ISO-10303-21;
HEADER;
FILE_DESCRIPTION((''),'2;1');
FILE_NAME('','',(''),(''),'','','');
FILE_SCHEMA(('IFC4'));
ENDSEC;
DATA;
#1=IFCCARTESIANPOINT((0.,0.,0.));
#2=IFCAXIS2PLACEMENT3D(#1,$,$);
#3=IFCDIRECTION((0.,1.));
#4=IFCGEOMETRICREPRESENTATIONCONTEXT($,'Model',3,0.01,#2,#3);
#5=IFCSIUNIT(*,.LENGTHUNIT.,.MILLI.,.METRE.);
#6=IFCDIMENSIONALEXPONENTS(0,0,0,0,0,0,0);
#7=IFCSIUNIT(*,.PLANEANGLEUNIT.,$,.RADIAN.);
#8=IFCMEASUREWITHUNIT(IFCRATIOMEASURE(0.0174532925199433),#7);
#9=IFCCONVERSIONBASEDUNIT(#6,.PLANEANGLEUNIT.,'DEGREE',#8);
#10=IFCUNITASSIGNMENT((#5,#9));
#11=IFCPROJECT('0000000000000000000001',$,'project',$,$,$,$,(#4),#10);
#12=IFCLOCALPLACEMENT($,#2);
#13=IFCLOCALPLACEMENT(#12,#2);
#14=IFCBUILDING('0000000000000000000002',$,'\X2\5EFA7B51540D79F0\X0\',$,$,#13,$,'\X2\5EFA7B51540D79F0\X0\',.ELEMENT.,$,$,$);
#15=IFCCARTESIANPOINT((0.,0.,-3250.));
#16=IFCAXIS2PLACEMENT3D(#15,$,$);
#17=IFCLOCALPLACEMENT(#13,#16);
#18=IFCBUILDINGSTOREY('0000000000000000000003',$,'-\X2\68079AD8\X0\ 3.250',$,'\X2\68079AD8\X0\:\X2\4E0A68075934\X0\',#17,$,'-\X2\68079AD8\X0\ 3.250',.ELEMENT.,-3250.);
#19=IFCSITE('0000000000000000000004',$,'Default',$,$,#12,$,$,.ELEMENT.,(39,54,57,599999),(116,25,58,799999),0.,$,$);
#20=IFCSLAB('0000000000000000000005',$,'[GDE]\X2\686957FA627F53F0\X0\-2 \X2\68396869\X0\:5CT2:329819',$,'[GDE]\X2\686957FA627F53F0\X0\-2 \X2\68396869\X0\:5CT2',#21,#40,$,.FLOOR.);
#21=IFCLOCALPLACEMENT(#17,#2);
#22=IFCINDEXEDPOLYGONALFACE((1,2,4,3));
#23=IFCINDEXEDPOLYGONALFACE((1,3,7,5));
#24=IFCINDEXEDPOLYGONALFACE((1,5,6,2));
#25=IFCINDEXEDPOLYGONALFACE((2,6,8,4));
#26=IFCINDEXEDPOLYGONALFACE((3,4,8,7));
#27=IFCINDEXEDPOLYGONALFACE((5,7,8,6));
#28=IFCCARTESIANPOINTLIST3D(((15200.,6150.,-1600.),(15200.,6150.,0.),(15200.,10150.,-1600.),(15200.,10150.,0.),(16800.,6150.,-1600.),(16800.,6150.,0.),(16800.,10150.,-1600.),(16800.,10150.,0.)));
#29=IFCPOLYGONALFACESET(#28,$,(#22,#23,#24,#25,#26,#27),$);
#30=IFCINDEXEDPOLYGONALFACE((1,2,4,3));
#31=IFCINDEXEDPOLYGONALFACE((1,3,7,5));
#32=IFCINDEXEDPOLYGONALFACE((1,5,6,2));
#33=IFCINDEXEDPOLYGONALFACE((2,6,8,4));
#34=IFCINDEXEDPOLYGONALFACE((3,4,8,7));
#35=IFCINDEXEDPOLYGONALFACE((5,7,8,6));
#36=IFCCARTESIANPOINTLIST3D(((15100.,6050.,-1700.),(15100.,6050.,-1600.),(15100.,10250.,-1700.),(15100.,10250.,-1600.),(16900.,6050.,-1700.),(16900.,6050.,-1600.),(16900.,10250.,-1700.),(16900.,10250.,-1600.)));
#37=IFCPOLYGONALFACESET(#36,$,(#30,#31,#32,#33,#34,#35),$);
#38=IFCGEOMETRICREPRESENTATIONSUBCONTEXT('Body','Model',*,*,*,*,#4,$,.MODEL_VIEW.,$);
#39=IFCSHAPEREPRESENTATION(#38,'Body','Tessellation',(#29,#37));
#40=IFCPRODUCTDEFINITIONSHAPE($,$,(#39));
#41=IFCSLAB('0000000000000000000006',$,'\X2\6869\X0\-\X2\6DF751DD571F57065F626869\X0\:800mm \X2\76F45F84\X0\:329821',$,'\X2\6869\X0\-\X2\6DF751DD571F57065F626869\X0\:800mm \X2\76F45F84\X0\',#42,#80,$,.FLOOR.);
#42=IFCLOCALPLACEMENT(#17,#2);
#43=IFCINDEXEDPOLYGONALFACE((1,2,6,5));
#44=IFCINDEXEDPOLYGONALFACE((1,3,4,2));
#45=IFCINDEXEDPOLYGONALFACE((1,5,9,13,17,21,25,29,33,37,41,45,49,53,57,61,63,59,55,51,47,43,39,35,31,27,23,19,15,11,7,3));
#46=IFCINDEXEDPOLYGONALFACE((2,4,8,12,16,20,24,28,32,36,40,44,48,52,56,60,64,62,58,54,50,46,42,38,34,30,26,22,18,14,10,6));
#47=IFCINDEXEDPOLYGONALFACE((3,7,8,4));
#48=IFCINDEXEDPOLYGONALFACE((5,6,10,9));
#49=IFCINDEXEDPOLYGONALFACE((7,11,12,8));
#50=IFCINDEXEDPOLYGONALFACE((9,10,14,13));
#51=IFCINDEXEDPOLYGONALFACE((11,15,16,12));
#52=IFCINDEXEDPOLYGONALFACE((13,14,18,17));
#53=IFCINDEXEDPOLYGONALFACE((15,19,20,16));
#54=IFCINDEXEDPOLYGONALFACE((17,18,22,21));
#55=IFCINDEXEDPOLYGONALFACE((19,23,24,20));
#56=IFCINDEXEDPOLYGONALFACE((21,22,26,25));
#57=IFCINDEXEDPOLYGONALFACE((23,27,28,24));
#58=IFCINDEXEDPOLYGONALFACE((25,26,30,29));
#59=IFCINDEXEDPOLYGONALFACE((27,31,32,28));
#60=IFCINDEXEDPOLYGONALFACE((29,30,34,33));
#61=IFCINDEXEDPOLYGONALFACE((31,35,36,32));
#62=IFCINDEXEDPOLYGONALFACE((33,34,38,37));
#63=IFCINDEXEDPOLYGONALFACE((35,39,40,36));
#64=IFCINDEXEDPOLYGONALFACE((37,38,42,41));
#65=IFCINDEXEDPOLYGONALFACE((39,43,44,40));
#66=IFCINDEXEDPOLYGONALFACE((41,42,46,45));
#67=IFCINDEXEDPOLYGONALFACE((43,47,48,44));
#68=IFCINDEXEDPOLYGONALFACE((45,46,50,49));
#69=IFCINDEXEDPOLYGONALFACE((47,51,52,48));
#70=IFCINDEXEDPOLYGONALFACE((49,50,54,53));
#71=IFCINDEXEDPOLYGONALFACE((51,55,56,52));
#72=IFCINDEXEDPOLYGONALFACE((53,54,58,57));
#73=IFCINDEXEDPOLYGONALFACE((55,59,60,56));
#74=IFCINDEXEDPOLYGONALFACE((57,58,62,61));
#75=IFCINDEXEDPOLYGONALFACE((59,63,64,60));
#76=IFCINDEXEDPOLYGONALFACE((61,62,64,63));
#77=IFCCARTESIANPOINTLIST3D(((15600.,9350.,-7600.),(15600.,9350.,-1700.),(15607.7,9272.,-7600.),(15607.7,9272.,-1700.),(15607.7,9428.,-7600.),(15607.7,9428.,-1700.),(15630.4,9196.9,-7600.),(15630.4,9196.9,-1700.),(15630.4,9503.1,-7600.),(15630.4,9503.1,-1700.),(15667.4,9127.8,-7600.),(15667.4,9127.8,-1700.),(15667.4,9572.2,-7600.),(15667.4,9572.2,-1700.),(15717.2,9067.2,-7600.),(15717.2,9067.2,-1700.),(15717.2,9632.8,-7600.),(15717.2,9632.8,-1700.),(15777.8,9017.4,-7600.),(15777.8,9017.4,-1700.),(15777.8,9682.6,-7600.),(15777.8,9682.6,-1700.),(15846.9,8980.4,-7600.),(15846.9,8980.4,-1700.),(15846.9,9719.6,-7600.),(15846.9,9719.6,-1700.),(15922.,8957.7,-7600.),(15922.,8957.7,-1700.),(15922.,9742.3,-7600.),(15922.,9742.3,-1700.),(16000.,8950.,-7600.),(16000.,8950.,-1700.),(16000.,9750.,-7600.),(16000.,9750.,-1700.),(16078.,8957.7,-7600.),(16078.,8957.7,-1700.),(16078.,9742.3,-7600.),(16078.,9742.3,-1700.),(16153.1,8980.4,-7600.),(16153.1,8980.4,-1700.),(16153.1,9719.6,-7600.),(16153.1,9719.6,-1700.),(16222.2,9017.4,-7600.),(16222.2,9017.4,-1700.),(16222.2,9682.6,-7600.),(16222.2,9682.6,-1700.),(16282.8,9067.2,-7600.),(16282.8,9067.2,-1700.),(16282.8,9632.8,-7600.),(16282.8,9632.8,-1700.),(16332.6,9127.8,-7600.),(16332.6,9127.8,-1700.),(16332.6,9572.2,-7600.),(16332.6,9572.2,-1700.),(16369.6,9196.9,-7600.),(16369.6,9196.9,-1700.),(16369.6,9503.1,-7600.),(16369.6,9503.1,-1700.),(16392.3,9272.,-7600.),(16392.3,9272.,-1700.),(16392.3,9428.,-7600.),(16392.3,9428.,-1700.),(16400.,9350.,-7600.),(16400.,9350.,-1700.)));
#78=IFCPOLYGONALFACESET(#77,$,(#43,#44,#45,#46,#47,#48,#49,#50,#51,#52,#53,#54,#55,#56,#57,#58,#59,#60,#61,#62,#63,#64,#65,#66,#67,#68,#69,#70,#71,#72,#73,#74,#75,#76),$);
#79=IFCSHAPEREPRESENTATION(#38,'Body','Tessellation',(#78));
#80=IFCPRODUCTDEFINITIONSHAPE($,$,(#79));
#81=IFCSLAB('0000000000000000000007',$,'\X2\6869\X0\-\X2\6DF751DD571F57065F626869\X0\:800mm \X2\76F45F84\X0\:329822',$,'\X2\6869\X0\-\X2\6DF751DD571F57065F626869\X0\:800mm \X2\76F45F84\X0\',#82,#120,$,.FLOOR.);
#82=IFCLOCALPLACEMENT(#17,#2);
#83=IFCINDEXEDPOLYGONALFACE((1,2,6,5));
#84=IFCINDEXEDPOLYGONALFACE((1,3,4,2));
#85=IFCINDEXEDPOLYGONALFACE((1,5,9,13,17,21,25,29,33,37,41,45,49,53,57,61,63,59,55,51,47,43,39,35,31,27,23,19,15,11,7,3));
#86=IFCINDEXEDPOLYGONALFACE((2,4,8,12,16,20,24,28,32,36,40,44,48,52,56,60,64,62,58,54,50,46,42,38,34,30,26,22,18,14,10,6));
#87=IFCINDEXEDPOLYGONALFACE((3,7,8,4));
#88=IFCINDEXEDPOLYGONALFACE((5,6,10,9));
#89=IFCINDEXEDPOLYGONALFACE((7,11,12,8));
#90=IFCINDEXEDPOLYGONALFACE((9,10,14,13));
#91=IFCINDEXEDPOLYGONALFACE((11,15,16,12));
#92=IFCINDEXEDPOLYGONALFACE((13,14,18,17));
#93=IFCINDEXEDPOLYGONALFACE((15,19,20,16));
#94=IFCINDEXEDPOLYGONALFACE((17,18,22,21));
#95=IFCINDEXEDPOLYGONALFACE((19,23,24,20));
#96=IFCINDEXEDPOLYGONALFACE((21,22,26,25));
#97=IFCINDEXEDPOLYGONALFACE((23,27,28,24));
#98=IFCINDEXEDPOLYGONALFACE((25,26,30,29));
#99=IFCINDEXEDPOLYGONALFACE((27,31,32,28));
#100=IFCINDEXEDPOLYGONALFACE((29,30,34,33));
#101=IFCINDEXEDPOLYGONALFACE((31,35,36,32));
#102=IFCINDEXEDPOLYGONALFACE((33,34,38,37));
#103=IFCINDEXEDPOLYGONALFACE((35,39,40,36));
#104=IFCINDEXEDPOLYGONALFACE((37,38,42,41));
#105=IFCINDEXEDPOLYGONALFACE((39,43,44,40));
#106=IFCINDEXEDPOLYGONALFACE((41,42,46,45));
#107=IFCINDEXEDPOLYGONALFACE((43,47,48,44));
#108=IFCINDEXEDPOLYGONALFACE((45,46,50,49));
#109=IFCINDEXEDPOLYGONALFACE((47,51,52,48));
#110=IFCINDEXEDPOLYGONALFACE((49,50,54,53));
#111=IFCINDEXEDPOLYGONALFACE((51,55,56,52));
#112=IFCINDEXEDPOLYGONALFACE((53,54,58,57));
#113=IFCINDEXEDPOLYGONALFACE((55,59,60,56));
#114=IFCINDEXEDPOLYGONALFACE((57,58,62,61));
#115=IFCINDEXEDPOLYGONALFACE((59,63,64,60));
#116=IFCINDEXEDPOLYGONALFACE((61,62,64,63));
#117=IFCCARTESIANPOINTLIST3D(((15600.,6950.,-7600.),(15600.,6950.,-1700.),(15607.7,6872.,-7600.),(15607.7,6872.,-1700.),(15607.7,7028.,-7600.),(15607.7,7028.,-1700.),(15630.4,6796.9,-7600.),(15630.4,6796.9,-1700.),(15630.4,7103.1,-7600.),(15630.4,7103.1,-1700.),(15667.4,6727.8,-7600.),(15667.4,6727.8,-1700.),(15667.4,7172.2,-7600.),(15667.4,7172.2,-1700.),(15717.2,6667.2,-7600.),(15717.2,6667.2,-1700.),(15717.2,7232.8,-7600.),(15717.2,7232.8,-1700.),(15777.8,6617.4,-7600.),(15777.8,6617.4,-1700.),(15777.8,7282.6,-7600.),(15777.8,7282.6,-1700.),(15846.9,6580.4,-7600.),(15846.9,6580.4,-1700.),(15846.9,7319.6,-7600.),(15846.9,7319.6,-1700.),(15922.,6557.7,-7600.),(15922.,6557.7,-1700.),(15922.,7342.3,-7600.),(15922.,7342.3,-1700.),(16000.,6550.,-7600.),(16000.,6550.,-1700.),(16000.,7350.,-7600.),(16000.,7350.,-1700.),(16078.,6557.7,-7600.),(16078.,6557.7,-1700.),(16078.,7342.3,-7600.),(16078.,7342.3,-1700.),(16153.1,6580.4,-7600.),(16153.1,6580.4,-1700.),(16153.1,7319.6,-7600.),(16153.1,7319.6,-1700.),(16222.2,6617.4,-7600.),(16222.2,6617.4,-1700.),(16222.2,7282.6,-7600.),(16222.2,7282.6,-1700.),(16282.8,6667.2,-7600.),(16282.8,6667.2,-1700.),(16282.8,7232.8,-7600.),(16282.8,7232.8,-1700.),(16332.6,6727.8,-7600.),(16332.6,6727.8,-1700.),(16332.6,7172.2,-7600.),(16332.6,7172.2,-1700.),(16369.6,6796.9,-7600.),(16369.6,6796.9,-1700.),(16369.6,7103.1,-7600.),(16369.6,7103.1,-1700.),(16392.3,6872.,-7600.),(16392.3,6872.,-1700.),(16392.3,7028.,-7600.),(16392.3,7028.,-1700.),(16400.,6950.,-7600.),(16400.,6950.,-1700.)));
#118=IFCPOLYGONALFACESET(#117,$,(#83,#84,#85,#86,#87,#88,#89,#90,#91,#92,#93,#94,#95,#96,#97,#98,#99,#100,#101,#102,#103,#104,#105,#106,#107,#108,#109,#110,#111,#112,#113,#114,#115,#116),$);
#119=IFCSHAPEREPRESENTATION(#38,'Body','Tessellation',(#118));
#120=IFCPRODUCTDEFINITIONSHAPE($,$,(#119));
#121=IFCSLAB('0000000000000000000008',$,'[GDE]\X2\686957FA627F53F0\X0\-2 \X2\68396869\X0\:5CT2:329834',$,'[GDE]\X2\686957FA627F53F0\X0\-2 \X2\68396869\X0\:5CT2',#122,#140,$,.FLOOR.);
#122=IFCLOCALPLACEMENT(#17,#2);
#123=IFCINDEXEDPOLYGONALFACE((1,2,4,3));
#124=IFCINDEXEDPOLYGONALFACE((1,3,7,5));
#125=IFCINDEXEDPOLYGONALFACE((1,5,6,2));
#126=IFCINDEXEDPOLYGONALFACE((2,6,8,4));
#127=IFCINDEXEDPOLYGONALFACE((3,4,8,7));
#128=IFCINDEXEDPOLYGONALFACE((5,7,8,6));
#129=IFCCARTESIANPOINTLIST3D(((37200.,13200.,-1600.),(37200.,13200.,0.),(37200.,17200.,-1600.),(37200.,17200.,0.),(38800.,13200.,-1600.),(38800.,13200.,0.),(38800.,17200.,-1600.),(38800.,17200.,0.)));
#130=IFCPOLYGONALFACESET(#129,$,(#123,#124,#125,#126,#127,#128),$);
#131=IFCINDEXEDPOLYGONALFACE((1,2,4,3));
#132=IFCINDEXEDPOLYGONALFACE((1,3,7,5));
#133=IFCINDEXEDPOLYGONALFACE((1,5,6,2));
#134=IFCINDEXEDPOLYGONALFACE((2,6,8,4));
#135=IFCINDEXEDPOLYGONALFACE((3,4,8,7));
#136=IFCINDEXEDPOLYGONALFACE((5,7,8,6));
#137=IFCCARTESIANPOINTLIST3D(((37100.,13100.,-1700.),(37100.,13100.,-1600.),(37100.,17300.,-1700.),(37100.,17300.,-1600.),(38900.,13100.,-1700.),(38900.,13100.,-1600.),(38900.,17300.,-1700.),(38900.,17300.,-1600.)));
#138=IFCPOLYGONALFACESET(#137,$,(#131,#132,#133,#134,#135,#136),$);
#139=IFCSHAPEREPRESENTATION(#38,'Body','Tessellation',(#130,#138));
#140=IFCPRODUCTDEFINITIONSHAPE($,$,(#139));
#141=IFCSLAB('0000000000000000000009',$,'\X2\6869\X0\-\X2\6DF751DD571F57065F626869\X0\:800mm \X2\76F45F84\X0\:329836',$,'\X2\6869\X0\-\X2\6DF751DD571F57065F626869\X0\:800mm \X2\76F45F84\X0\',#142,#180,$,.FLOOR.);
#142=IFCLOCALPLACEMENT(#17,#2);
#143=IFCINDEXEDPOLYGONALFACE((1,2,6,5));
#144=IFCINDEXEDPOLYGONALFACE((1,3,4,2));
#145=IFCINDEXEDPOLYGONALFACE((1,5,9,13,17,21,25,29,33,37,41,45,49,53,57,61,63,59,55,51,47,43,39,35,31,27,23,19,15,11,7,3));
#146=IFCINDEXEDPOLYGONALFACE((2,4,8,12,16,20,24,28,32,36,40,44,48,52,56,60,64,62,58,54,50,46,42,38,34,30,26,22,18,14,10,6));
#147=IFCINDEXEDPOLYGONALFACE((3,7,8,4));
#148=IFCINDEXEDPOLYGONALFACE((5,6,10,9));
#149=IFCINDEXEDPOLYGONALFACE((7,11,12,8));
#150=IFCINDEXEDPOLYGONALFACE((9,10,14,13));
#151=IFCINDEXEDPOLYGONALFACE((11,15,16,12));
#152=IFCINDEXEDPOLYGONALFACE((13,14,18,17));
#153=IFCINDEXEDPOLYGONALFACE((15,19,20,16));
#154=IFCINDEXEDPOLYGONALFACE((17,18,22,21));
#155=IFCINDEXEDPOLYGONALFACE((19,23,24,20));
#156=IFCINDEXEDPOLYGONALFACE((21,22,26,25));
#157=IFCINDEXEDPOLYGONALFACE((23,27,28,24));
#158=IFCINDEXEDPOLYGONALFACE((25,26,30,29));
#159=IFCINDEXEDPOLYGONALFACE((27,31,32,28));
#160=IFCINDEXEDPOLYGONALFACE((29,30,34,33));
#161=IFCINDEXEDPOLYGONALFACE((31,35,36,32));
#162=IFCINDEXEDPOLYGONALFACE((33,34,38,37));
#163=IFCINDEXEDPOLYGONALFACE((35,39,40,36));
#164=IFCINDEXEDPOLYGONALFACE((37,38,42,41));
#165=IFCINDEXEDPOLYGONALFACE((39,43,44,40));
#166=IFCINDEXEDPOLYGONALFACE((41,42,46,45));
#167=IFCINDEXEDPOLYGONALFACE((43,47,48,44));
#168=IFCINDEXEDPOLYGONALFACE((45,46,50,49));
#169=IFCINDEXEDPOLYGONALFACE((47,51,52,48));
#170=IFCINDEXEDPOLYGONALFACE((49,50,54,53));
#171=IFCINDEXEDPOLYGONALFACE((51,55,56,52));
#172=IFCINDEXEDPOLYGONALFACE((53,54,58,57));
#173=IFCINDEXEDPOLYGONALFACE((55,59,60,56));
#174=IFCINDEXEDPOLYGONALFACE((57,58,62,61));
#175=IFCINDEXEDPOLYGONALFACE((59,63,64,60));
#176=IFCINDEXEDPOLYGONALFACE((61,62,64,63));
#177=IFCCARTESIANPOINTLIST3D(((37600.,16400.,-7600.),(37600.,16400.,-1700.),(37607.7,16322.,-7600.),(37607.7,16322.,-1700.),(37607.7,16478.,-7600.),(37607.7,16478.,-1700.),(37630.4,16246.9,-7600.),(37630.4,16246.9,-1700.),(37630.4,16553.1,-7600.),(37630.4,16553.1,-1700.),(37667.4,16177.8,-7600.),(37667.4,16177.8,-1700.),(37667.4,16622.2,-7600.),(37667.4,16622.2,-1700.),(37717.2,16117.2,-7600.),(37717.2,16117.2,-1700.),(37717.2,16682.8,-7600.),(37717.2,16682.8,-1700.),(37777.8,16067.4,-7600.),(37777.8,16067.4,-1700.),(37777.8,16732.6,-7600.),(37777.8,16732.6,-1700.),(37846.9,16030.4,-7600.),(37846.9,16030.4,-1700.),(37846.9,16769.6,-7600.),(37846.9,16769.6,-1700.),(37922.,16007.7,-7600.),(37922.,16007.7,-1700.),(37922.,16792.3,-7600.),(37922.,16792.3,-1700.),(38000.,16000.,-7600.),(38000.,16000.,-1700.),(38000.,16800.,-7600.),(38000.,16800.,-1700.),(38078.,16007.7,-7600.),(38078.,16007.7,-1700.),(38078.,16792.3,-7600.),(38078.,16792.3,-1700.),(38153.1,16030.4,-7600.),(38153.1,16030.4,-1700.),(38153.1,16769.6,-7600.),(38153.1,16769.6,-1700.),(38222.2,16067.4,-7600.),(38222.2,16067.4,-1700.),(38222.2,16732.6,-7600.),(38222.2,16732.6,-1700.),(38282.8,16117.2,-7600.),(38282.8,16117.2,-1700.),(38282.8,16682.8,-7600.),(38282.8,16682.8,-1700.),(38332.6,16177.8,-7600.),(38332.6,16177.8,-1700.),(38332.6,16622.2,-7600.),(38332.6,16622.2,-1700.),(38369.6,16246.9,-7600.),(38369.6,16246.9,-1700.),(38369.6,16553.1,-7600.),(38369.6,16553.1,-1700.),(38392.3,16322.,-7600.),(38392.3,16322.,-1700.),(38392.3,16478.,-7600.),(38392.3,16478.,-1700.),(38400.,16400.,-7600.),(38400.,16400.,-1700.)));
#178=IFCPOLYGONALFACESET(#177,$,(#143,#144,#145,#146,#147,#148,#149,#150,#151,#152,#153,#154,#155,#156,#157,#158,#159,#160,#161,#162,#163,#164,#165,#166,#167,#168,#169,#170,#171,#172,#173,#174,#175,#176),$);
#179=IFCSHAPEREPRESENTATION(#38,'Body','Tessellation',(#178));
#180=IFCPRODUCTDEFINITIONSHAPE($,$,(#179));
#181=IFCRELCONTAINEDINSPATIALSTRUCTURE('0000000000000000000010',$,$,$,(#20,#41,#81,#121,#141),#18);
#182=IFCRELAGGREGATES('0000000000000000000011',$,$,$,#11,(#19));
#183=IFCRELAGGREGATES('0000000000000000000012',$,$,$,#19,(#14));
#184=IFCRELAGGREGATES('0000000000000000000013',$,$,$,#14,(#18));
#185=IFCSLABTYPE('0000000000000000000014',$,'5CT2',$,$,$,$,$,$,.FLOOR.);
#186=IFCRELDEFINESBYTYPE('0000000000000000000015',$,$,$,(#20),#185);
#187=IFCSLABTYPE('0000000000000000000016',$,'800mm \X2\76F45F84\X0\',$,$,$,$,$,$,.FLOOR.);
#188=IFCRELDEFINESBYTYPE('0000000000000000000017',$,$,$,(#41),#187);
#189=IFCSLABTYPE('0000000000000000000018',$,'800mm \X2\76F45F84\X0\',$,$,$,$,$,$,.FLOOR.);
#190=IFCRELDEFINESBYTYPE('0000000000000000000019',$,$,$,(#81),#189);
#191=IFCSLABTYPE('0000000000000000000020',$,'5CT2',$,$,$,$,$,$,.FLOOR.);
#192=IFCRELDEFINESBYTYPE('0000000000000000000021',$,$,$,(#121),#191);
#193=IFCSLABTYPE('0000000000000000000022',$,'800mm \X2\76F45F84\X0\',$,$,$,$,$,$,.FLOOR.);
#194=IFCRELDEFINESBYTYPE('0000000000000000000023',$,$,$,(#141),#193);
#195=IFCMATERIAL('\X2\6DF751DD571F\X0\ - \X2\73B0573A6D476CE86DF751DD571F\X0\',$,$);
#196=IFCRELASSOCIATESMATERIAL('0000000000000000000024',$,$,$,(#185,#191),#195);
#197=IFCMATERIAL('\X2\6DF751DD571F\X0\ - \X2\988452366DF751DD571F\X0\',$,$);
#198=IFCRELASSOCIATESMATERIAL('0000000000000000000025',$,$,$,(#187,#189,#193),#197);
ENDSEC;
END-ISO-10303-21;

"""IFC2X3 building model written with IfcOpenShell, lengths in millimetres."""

from ifc_helpers import new_model, entity, si_unit, converted_unit, direction, frame, frame_2d, origin, origin_2d_with_axis, place, context, subcontext, project, spatial, rectangle, circle, extrude, material, type_object, element, save


model = new_model("IFC2X3")

# Units and contexts
model_context = context("Model", 3, precision=0.01, world=origin(), true_north=direction((0.0, 1.0)))
body_context = subcontext(model_context, "Body", "Model", "MODEL_VIEW")
ifc_project = project(units=[si_unit("LENGTHUNIT", "METRE", prefix="MILLI"), converted_unit("PLANEANGLEUNIT", "DEGREE", entity("IfcRatioMeasure", 0.0174532925199433), si_unit("PLANEANGLEUNIT", "RADIAN"), dimensions=[0, 0, 0, 0, 0, 0, 0])], contexts=[model_context])

# Site, building, storey
site_placement = place(None, origin())
site = spatial("IfcSite", under=ifc_project, at=site_placement, Name="Default", CompositionType="ELEMENT", RefLatitude=(39, 54, 57, 599999), RefLongitude=(116, 25, 58, 799999), RefElevation=0.0)
building_placement = place(site_placement, origin())
building = spatial("IfcBuilding", under=site, at=building_placement, Name="建筑名称", LongName="建筑名称", CompositionType="ELEMENT")
storey_placement = place(building_placement, frame((0.0, 0.0, -3250.0)))
storey = spatial("IfcBuildingStorey", under=building, at=storey_placement, Name="-标高 3.250", ObjectType="标高:上标头", LongName="-标高 3.250", CompositionType="ELEMENT", Elevation=-3250.0)

# Slabs
ifc_material_1 = material(Name="混凝土 - 现场浇注混凝土")
slab_type_1 = type_object("IfcSlabType", Name="5CT2", PredefinedType="FLOOR", material=ifc_material_1)
slab_1_placement = place(storey_placement, origin())
element("IfcSlab", 1, at=slab_1_placement, inside=storey, type_object=slab_type_1, Name="[GDE]桩基承台-2 根桩:5CT2:329819", ObjectType="[GDE]桩基承台-2 根桩:5CT2", PredefinedType="FLOOR", context=body_context, shape_type="SweptSolid", body=[
    extrude(rectangle(XDim=4000.0, YDim=1600.0, at=frame_2d((0.0, 0.0), x_axis=(1.0, 0.0))), frame((16000.0, 8150.0, -1600.0), z_axis=(0.0, 0.0, 1.0), x_axis=(0.0, 1.0, 0.0)), (0.0, 0.0, 1.0), 1600.0),
    extrude(rectangle(XDim=4200.0, YDim=1800.0, at=frame_2d((0.0, 0.0), x_axis=(1.0, 0.0))), frame((16000.0, 8150.0, -1700.0), z_axis=(0.0, 0.0, 1.0), x_axis=(0.0, 1.0, 0.0)), (0.0, 0.0, 1.0), 100.0),
])
ifc_material_2 = material(Name="混凝土 - 预制混凝土")
slab_type_2 = type_object("IfcSlabType", Name="800mm 直径", PredefinedType="FLOOR", material=ifc_material_2)
slab_2_placement = place(storey_placement, origin())
element("IfcSlab", 2, at=slab_2_placement, inside=storey, type_object=slab_type_2, Name="桩-混凝土圆形桩:800mm 直径:329821", ObjectType="桩-混凝土圆形桩:800mm 直径", PredefinedType="FLOOR", context=body_context, shape_type="SweptSolid", body=[
    extrude(circle(Radius=400.0, at=origin_2d_with_axis()), frame((16000.0, 9350.0, -7600.0), z_axis=(0.0, 0.0, 1.0), x_axis=(0.0, -1.0, 0.0)), (0.0, 0.0, 1.0), 5900.0),
])
slab_type_3 = type_object("IfcSlabType", Name="800mm 直径", PredefinedType="FLOOR", material=ifc_material_2)
slab_3_placement = place(storey_placement, origin())
element("IfcSlab", 3, at=slab_3_placement, inside=storey, type_object=slab_type_3, Name="桩-混凝土圆形桩:800mm 直径:329822", ObjectType="桩-混凝土圆形桩:800mm 直径", PredefinedType="FLOOR", context=body_context, shape_type="SweptSolid", body=[
    extrude(circle(Radius=400.0, at=origin_2d_with_axis()), frame((16000.0, 6950.0, -7600.0), z_axis=(0.0, 0.0, 1.0), x_axis=(0.0, -1.0, 0.0)), (0.0, 0.0, 1.0), 5900.0),
])
slab_type_4 = type_object("IfcSlabType", Name="5CT2", PredefinedType="FLOOR", material=ifc_material_1)
slab_4_placement = place(storey_placement, origin())
element("IfcSlab", 4, at=slab_4_placement, inside=storey, type_object=slab_type_4, Name="[GDE]桩基承台-2 根桩:5CT2:329834", ObjectType="[GDE]桩基承台-2 根桩:5CT2", PredefinedType="FLOOR", context=body_context, shape_type="SweptSolid", body=[
    extrude(rectangle(XDim=4000.0, YDim=1600.0, at=frame_2d((0.0, 0.0), x_axis=(1.0, 0.0))), frame((38000.0, 15200.0, -1600.0), z_axis=(0.0, 0.0, 1.0), x_axis=(0.0, 1.0, 0.0)), (0.0, 0.0, 1.0), 1600.0),
    extrude(rectangle(XDim=4200.0, YDim=1800.0, at=frame_2d((0.0, 0.0), x_axis=(1.0, 0.0))), frame((38000.0, 15200.0, -1700.0), z_axis=(0.0, 0.0, 1.0), x_axis=(0.0, 1.0, 0.0)), (0.0, 0.0, 1.0), 100.0),
])
slab_type_5 = type_object("IfcSlabType", Name="800mm 直径", PredefinedType="FLOOR", material=ifc_material_2)
slab_5_placement = place(storey_placement, origin())
element("IfcSlab", 5, at=slab_5_placement, inside=storey, type_object=slab_type_5, Name="桩-混凝土圆形桩:800mm 直径:329836", ObjectType="桩-混凝土圆形桩:800mm 直径", PredefinedType="FLOOR", context=body_context, shape_type="SweptSolid", body=[
    extrude(circle(Radius=400.0, at=origin_2d_with_axis()), frame((38000.0, 16400.0, -7600.0), z_axis=(0.0, 0.0, 1.0), x_axis=(0.0, -1.0, 0.0)), (0.0, 0.0, 1.0), 5900.0),
])

save(model, "model.ifc")
